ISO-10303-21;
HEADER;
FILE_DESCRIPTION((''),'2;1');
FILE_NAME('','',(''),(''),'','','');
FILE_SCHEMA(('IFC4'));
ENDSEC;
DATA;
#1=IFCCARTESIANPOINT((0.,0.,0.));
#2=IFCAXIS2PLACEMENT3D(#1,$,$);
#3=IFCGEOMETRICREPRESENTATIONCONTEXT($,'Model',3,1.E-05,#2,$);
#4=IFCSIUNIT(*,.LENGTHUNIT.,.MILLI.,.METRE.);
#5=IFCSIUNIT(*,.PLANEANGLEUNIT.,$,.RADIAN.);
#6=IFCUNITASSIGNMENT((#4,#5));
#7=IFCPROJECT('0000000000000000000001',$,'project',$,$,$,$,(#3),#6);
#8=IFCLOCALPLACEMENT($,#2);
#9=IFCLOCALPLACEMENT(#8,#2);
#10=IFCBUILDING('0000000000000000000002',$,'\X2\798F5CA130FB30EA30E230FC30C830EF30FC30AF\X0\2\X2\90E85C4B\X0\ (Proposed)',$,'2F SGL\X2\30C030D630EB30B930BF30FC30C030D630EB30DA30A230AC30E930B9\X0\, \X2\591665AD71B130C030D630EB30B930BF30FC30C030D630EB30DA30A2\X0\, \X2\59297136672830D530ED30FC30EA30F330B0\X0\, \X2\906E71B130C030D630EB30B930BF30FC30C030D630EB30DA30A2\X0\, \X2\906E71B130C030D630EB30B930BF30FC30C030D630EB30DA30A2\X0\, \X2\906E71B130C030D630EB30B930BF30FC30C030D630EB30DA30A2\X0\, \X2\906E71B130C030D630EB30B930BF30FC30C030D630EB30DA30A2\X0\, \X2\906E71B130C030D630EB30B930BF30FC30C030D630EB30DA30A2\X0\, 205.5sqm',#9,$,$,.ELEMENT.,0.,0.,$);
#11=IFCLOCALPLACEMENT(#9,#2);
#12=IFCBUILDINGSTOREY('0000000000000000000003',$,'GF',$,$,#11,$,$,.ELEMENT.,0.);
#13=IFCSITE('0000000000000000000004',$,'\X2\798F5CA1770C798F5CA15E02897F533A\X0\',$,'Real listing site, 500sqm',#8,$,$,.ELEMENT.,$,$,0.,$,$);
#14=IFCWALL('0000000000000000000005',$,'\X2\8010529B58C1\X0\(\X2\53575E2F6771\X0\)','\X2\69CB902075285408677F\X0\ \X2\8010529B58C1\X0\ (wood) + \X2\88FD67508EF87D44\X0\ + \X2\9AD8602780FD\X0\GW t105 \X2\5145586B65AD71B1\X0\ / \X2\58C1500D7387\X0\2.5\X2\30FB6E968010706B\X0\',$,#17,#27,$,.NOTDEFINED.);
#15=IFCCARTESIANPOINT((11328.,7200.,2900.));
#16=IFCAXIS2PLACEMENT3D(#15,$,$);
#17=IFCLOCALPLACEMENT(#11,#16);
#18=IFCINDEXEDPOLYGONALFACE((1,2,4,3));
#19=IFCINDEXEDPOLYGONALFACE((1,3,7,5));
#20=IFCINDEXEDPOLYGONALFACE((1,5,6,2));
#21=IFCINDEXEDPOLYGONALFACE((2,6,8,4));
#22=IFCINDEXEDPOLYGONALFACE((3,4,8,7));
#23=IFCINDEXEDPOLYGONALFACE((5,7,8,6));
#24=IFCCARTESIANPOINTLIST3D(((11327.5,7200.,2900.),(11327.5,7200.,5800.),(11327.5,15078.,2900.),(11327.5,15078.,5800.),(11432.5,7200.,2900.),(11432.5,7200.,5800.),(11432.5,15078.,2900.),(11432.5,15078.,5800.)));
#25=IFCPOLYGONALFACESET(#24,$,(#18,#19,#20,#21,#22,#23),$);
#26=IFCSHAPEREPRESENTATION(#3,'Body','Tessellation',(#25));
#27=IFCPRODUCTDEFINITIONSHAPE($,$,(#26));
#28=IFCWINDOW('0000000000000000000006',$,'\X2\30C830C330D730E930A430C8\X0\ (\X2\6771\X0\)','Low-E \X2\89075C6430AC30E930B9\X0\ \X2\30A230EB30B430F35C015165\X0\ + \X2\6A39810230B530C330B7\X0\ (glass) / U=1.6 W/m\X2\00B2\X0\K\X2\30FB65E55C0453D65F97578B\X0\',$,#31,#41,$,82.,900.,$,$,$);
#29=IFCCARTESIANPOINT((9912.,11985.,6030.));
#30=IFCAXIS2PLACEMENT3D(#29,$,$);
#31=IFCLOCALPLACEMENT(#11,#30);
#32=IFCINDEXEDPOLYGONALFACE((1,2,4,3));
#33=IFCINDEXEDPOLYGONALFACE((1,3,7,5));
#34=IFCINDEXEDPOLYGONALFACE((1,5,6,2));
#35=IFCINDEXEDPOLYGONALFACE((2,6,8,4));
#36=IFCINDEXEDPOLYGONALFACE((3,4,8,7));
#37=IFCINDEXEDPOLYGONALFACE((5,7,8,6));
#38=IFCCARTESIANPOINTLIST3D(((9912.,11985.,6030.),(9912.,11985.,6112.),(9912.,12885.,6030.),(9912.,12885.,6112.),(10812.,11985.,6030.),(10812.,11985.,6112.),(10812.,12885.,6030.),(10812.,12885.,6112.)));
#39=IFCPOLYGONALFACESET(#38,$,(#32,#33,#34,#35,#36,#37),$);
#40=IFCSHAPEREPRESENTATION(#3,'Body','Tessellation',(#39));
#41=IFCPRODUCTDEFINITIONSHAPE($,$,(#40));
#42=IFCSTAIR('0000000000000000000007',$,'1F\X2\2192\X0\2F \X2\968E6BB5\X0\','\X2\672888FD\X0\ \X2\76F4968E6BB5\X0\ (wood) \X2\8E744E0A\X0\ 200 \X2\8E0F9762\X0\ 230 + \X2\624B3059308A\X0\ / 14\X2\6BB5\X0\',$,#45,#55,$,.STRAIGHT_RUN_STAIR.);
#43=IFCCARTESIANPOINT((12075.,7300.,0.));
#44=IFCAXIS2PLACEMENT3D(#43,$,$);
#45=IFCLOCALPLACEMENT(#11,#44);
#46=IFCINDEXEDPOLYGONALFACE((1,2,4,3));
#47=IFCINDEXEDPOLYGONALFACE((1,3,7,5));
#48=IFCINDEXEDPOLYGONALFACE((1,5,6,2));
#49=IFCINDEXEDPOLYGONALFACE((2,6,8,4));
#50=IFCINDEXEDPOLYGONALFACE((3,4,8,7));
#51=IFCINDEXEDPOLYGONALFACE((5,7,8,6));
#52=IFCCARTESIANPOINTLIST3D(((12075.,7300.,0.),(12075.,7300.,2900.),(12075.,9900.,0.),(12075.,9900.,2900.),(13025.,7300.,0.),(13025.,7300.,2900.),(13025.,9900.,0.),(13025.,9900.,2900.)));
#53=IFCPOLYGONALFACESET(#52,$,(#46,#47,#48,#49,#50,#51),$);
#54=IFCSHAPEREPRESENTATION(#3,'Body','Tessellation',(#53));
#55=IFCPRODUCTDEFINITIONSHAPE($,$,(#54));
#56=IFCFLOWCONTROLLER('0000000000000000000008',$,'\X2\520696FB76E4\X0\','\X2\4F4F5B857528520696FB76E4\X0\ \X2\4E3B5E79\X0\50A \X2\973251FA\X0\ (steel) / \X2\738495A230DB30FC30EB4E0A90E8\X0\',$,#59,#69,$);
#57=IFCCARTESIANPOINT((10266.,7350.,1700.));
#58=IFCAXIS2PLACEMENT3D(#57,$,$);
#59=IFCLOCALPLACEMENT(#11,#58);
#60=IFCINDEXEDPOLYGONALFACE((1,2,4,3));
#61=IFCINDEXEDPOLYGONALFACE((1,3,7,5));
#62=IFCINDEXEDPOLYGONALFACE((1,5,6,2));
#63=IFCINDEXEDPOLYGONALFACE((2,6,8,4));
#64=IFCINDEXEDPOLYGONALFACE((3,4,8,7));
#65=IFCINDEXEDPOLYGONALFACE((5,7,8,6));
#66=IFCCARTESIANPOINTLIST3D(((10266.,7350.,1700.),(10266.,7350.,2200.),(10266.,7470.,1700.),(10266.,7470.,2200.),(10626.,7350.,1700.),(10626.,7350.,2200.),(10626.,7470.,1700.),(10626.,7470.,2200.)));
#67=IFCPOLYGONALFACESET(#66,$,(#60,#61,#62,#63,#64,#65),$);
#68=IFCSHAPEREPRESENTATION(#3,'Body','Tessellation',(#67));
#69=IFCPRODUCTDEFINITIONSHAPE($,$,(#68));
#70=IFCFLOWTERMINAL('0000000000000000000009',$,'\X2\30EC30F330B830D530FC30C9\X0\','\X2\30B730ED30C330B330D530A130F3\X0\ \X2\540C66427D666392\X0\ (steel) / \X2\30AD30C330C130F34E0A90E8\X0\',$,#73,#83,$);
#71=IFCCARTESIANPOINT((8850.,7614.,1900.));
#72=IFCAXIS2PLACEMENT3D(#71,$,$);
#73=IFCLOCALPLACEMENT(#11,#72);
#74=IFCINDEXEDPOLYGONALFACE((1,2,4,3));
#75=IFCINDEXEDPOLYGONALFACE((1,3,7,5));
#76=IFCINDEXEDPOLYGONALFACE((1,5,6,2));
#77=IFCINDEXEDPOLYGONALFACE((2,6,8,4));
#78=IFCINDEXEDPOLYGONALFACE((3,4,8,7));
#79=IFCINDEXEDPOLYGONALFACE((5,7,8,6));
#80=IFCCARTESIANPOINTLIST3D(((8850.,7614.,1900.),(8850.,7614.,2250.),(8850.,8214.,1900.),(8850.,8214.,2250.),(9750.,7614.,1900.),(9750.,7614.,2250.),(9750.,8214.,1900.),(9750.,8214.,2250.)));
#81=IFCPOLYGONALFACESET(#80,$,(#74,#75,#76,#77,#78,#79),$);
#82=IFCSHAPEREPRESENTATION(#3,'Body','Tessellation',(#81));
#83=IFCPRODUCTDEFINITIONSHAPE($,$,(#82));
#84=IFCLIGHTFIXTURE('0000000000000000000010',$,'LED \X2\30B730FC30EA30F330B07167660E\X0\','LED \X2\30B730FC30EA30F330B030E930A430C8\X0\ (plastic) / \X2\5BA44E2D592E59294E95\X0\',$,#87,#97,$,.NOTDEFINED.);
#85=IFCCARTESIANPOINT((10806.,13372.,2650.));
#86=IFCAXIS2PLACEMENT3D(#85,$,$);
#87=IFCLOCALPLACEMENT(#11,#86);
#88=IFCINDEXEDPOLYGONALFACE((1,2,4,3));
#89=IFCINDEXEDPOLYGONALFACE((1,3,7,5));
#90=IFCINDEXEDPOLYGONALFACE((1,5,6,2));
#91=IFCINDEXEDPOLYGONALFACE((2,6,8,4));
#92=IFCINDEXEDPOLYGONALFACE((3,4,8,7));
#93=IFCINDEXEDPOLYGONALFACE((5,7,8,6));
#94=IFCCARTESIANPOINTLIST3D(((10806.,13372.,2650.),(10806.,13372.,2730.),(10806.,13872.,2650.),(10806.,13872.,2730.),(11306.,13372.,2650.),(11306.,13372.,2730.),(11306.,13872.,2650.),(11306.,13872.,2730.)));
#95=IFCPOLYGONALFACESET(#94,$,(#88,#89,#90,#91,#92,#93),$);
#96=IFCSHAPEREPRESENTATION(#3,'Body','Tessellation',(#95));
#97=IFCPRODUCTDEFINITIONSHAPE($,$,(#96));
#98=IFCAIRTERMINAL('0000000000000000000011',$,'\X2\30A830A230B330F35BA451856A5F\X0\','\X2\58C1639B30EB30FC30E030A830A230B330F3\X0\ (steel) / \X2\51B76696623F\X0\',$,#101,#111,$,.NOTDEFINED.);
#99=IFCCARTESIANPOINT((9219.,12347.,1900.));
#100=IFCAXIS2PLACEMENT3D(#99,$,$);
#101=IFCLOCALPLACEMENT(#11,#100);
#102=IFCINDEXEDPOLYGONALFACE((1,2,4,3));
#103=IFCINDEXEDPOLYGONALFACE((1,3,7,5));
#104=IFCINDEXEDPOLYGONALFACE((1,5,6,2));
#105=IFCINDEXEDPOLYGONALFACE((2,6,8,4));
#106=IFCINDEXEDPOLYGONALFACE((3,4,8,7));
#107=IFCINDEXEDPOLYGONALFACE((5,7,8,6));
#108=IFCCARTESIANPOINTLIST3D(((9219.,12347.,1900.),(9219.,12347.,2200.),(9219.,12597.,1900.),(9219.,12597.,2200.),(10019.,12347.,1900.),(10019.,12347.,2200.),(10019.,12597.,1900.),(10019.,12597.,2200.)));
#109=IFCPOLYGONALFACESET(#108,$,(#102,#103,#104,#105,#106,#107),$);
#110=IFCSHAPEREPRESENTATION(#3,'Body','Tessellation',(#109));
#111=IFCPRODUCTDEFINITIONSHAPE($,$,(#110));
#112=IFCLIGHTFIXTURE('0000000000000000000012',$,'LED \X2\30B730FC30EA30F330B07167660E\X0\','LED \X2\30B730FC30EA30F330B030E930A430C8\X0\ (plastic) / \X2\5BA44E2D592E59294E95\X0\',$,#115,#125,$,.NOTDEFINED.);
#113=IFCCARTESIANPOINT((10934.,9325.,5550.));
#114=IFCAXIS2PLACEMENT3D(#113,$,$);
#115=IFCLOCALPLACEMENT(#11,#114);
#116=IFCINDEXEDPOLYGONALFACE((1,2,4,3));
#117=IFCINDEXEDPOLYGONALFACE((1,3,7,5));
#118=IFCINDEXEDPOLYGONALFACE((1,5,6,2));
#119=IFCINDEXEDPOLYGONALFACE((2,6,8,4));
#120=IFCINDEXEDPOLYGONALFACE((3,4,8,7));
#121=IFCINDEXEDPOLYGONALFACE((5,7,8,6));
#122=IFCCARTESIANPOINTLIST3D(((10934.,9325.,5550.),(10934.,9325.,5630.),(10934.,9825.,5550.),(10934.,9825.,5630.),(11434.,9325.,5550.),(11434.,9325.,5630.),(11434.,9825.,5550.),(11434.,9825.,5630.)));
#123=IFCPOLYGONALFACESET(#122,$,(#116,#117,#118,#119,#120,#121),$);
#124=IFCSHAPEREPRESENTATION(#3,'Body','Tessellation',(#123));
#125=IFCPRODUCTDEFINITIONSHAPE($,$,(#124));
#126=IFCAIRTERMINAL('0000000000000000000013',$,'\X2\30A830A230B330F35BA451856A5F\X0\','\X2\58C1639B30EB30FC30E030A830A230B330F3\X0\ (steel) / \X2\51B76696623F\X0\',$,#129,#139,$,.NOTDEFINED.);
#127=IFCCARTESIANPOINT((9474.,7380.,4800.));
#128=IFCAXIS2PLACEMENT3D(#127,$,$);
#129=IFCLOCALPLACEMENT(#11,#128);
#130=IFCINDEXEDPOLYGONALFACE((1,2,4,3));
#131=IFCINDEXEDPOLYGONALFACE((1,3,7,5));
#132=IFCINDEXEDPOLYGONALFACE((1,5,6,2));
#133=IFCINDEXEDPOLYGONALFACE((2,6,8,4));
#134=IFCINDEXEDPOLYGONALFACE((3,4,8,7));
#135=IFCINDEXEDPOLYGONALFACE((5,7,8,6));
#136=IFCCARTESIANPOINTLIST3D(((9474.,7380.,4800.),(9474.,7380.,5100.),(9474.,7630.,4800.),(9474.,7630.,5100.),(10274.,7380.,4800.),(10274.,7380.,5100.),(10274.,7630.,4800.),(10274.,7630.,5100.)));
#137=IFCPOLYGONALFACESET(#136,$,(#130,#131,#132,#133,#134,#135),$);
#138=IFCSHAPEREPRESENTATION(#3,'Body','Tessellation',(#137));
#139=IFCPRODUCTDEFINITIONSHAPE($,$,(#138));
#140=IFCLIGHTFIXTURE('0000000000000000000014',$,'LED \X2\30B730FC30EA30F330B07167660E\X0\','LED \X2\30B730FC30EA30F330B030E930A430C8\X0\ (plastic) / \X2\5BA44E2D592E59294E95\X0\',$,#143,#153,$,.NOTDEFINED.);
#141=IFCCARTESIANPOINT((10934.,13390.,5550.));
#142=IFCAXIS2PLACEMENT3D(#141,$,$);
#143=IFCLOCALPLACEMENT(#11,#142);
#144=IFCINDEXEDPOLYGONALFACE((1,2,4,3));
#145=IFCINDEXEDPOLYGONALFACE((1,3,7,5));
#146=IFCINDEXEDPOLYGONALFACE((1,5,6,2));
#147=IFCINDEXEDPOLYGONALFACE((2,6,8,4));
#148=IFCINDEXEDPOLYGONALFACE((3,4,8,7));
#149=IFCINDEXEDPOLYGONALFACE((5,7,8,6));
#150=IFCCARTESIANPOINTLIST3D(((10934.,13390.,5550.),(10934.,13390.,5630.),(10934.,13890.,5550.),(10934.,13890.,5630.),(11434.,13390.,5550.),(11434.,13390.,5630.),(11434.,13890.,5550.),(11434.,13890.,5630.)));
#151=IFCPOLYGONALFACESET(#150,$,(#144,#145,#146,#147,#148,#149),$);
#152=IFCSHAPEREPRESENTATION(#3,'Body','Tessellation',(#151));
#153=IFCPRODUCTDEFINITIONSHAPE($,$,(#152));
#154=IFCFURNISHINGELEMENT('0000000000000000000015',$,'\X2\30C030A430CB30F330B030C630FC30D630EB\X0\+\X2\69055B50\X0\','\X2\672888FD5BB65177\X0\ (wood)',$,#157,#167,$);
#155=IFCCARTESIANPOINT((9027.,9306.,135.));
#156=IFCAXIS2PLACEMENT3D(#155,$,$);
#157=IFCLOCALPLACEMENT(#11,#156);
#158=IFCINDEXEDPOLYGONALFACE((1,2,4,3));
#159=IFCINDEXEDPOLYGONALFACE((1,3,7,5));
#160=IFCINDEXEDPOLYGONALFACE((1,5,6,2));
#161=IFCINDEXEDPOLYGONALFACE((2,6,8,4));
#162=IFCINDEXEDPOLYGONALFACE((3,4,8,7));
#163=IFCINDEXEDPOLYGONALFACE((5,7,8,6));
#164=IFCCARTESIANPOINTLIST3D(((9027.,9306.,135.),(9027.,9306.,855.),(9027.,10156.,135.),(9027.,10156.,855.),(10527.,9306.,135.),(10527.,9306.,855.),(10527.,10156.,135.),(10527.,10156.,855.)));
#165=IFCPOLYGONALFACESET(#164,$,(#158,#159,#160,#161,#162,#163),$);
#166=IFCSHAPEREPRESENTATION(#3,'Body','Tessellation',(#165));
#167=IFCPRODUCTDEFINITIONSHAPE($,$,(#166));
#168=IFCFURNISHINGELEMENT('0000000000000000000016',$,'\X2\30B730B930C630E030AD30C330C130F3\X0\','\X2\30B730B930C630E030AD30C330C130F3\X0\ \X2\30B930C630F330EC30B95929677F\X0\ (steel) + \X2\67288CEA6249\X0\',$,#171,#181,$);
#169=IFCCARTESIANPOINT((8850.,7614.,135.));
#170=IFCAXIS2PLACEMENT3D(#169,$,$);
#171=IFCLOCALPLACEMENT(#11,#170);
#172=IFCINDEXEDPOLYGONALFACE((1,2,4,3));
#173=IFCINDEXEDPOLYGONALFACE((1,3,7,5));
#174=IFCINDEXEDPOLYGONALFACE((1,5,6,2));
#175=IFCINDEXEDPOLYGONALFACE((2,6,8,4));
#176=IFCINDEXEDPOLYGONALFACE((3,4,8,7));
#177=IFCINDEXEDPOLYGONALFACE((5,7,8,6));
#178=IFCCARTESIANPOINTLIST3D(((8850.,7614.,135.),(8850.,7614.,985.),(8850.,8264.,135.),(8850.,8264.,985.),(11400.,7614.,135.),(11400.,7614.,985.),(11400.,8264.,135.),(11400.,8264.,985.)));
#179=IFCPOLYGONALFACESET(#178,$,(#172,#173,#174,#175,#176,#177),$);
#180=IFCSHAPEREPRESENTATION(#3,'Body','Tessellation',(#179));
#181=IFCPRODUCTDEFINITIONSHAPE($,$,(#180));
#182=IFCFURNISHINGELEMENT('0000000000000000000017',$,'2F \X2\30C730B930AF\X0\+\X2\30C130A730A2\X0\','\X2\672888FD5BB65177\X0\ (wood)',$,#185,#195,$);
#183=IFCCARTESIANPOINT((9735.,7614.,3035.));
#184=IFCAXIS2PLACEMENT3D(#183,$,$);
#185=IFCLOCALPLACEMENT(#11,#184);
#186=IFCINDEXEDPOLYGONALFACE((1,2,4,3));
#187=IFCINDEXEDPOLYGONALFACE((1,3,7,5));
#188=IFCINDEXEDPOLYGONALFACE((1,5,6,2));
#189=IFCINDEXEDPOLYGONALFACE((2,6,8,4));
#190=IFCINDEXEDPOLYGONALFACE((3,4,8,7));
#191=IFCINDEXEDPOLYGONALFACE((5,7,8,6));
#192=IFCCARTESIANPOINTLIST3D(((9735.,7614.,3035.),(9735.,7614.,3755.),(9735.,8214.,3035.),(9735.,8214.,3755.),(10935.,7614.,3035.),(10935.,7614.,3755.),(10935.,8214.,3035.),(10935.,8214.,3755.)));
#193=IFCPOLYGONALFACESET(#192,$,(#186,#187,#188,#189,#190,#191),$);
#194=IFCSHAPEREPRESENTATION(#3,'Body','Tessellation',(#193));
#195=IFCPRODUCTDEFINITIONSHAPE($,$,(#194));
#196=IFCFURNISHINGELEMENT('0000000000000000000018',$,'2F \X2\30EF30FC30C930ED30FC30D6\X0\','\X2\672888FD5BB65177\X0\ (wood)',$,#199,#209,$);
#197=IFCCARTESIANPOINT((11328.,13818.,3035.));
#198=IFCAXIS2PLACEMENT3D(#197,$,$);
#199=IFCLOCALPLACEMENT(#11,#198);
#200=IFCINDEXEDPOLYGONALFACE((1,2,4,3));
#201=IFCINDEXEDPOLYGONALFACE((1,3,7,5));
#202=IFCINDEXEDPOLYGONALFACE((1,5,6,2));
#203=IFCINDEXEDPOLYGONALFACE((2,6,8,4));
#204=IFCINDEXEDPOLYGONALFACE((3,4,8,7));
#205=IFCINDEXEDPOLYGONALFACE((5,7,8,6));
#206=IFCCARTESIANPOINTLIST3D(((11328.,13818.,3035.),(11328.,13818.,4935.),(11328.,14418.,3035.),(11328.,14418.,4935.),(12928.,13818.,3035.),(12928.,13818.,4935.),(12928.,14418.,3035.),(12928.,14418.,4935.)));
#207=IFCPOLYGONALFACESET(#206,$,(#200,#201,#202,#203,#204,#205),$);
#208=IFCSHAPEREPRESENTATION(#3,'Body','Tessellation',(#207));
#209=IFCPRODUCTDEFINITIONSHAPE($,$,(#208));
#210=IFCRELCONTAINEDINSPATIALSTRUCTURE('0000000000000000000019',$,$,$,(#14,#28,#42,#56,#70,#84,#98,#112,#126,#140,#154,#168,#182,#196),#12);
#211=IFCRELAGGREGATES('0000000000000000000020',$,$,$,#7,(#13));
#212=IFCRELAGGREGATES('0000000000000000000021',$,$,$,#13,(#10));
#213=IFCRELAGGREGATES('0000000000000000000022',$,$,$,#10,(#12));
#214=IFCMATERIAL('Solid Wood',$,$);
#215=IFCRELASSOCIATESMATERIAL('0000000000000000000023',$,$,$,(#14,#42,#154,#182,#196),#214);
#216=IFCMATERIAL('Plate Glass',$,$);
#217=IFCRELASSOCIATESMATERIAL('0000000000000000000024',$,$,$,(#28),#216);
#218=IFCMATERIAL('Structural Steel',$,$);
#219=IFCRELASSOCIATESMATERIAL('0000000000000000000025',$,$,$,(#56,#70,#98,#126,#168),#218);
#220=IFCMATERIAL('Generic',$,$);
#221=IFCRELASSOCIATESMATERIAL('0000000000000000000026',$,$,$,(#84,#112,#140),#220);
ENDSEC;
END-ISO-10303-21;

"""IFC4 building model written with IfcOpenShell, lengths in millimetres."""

from ifc_helpers import new_model, si_unit, frame, frame_2d, origin, place, context, project, spatial, rectangle, extrude, material, element, save


model = new_model("IFC4")

# Units and contexts
model_context = context("Model", 3, precision=1e-05, world=origin())
ifc_project = project(units=[si_unit("LENGTHUNIT", "METRE", prefix="MILLI"), si_unit("PLANEANGLEUNIT", "RADIAN")], contexts=[model_context])

# Site, building, storey
site_placement = place(None, origin())
site = spatial("IfcSite", under=ifc_project, at=site_placement, Name="福岡県福岡市西区", ObjectType="Real listing site, 500sqm", CompositionType="ELEMENT", RefElevation=0.0)
building_placement = place(site_placement, origin())
building = spatial("IfcBuilding", under=site, at=building_placement, Name="福岡・リモートワーク2部屋 (Proposed)", ObjectType="2F SGLダブルスターダブルペアガラス, 外断熱ダブルスターダブルペア, 天然木フローリング, 遮熱ダブルスターダブルペア, 遮熱ダブルスターダブルペア, 遮熱ダブルスターダブルペア, 遮熱ダブルスターダブルペア, 遮熱ダブルスターダブルペア, 205.5sqm", CompositionType="ELEMENT", ElevationOfRefHeight=0.0, ElevationOfTerrain=0.0)
storey_placement = place(building_placement, origin())
storey = spatial("IfcBuildingStorey", under=building, at=storey_placement, Name="GF", CompositionType="ELEMENT", Elevation=0.0)

# Shared definitions
ifc_material_1 = material(Name="Solid Wood")

# Wall
wall_1_placement = place(storey_placement, frame((11328.0, 7200.0, 2900.0)))
element("IfcWall", 1, at=wall_1_placement, inside=storey, material=ifc_material_1, Name="耐力壁(南帯東)", Description="構造用合板 耐力壁 (wood) + 製材軸組 + 高性能GW t105 充填断熱 / 壁倍率2.5・準耐火", PredefinedType="NOTDEFINED", context=model_context, shape_type="SweptSolid", body=[
    extrude(rectangle(XDim=105.0, YDim=7878.0, at=frame_2d((52.0, 3939.0))), frame((11328.0, 7200.0, 2900.0)), (0.0, 0.0, 1.0), 2900.0),
])

# Window
ifc_material_2 = material(Name="Plate Glass")
window_placement = place(storey_placement, frame((9912.0, 11985.0, 6030.0)))
element("IfcWindow", 2, at=window_placement, inside=storey, material=ifc_material_2, Name="トップライト (東)", Description="Low-E 複層ガラス アルゴン封入 + 樹脂サッシ (glass) / U=1.6 W/m²K・日射取得型", OverallHeight=82.0, OverallWidth=900.0, context=model_context, shape_type="SweptSolid", body=[
    extrude(rectangle(XDim=900.0, YDim=900.0, at=frame_2d((450.0, 450.0))), frame((9912.0, 11985.0, 6030.0)), (0.0, 0.0, 1.0), 82.0),
])

# Stair
stair_placement = place(storey_placement, frame((12075.0, 7300.0, 0.0)))
element("IfcStair", 3, at=stair_placement, inside=storey, material=ifc_material_1, Name="1F→2F 階段", Description="木製 直階段 (wood) 蹴上 200 踏面 230 + 手すり / 14段", PredefinedType="STRAIGHT_RUN_STAIR", context=model_context, shape_type="SweptSolid", body=[
    extrude(rectangle(XDim=950.0, YDim=2600.0, at=frame_2d((475.0, 1300.0))), frame((12075.0, 7300.0, 0.0)), (0.0, 0.0, 1.0), 2900.0),
])

# Flow controller
ifc_material_3 = material(Name="Structural Steel")
flow_controller_placement = place(storey_placement, frame((10266.0, 7350.0, 1700.0)))
element("IfcFlowController", 4, at=flow_controller_placement, inside=storey, material=ifc_material_3, Name="分電盤", Description="住宅用分電盤 主幹50A 露出 (steel) / 玄関ホール上部", context=model_context, shape_type="SweptSolid", body=[
    extrude(rectangle(XDim=360.0, YDim=120.0, at=frame_2d((180.0, 60.0))), frame((10266.0, 7350.0, 1700.0)), (0.0, 0.0, 1.0), 500.0),
])

# Flow terminal
flow_terminal_placement = place(storey_placement, frame((8850.0, 7614.0, 1900.0)))
element("IfcFlowTerminal", 5, at=flow_terminal_placement, inside=storey, material=ifc_material_3, Name="レンジフード", Description="シロッコファン 同時給排 (steel) / キッチン上部", context=model_context, shape_type="SweptSolid", body=[
    extrude(rectangle(XDim=900.0, YDim=600.0, at=frame_2d((450.0, 300.0))), frame((8850.0, 7614.0, 1900.0)), (0.0, 0.0, 1.0), 350.0),
])

# Light fixture
ifc_material_4 = material(Name="Generic")
light_fixture_1_placement = place(storey_placement, frame((10806.0, 13372.0, 2650.0)))
element("IfcLightFixture", 6, at=light_fixture_1_placement, inside=storey, material=ifc_material_4, Name="LED シーリング照明", Description="LED シーリングライト (plastic) / 室中央天井", PredefinedType="NOTDEFINED", context=model_context, shape_type="SweptSolid", body=[
    extrude(rectangle(XDim=500.0, YDim=500.0, at=frame_2d((250.0, 250.0))), frame((10806.0, 13372.0, 2650.0)), (0.0, 0.0, 1.0), 80.0),
])

# Air terminal
air_terminal_1_placement = place(storey_placement, frame((9219.0, 12347.0, 1900.0)))
element("IfcAirTerminal", 7, at=air_terminal_1_placement, inside=storey, material=ifc_material_3, Name="エアコン室内機", Description="壁掛ルームエアコン (steel) / 冷暖房", PredefinedType="NOTDEFINED", context=model_context, shape_type="SweptSolid", body=[
    extrude(rectangle(XDim=800.0, YDim=250.0, at=frame_2d((400.0, 125.0))), frame((9219.0, 12347.0, 1900.0)), (0.0, 0.0, 1.0), 300.0),
])

# Light fixture
light_fixture_2_placement = place(storey_placement, frame((10934.0, 9325.0, 5550.0)))
element("IfcLightFixture", 8, at=light_fixture_2_placement, inside=storey, material=ifc_material_4, Name="LED シーリング照明", Description="LED シーリングライト (plastic) / 室中央天井", PredefinedType="NOTDEFINED", context=model_context, shape_type="SweptSolid", body=[
    extrude(rectangle(XDim=500.0, YDim=500.0, at=frame_2d((250.0, 250.0))), frame((10934.0, 9325.0, 5550.0)), (0.0, 0.0, 1.0), 80.0),
])

# Air terminal
air_terminal_2_placement = place(storey_placement, frame((9474.0, 7380.0, 4800.0)))
element("IfcAirTerminal", 9, at=air_terminal_2_placement, inside=storey, material=ifc_material_3, Name="エアコン室内機", Description="壁掛ルームエアコン (steel) / 冷暖房", PredefinedType="NOTDEFINED", context=model_context, shape_type="SweptSolid", body=[
    extrude(rectangle(XDim=800.0, YDim=250.0, at=frame_2d((400.0, 125.0))), frame((9474.0, 7380.0, 4800.0)), (0.0, 0.0, 1.0), 300.0),
])

# Light fixture
light_fixture_3_placement = place(storey_placement, frame((10934.0, 13390.0, 5550.0)))
element("IfcLightFixture", 10, at=light_fixture_3_placement, inside=storey, material=ifc_material_4, Name="LED シーリング照明", Description="LED シーリングライト (plastic) / 室中央天井", PredefinedType="NOTDEFINED", context=model_context, shape_type="SweptSolid", body=[
    extrude(rectangle(XDim=500.0, YDim=500.0, at=frame_2d((250.0, 250.0))), frame((10934.0, 13390.0, 5550.0)), (0.0, 0.0, 1.0), 80.0),
])

# Furnishing elements
furnishing_1_placement = place(storey_placement, frame((9027.0, 9306.0, 135.0)))
element("IfcFurnishingElement", 11, at=furnishing_1_placement, inside=storey, material=ifc_material_1, Name="ダイニングテーブル+椅子", Description="木製家具 (wood)", context=model_context, shape_type="SweptSolid", body=[
    extrude(rectangle(XDim=1500.0, YDim=850.0, at=frame_2d((750.0, 425.0))), frame((9027.0, 9306.0, 135.0)), (0.0, 0.0, 1.0), 720.0),
])
furnishing_2_placement = place(storey_placement, frame((8850.0, 7614.0, 135.0)))
element("IfcFurnishingElement", 12, at=furnishing_2_placement, inside=storey, material=ifc_material_3, Name="システムキッチン", Description="システムキッチン ステンレス天板 (steel) + 木質扉", context=model_context, shape_type="SweptSolid", body=[
    extrude(rectangle(XDim=2550.0, YDim=650.0, at=frame_2d((1275.0, 325.0))), frame((8850.0, 7614.0, 135.0)), (0.0, 0.0, 1.0), 850.0),
])
furnishing_3_placement = place(storey_placement, frame((9735.0, 7614.0, 3035.0)))
element("IfcFurnishingElement", 13, at=furnishing_3_placement, inside=storey, material=ifc_material_1, Name="2F デスク+チェア", Description="木製家具 (wood)", context=model_context, shape_type="SweptSolid", body=[
    extrude(rectangle(XDim=1200.0, YDim=600.0, at=frame_2d((600.0, 300.0))), frame((9735.0, 7614.0, 3035.0)), (0.0, 0.0, 1.0), 720.0),
])
furnishing_4_placement = place(storey_placement, frame((11328.0, 13818.0, 3035.0)))
element("IfcFurnishingElement", 14, at=furnishing_4_placement, inside=storey, material=ifc_material_1, Name="2F ワードローブ", Description="木製家具 (wood)", context=model_context, shape_type="SweptSolid", body=[
    extrude(rectangle(XDim=1600.0, YDim=600.0, at=frame_2d((800.0, 300.0))), frame((11328.0, 13818.0, 3035.0)), (0.0, 0.0, 1.0), 1900.0),
])

save(model, "model.ifc")
